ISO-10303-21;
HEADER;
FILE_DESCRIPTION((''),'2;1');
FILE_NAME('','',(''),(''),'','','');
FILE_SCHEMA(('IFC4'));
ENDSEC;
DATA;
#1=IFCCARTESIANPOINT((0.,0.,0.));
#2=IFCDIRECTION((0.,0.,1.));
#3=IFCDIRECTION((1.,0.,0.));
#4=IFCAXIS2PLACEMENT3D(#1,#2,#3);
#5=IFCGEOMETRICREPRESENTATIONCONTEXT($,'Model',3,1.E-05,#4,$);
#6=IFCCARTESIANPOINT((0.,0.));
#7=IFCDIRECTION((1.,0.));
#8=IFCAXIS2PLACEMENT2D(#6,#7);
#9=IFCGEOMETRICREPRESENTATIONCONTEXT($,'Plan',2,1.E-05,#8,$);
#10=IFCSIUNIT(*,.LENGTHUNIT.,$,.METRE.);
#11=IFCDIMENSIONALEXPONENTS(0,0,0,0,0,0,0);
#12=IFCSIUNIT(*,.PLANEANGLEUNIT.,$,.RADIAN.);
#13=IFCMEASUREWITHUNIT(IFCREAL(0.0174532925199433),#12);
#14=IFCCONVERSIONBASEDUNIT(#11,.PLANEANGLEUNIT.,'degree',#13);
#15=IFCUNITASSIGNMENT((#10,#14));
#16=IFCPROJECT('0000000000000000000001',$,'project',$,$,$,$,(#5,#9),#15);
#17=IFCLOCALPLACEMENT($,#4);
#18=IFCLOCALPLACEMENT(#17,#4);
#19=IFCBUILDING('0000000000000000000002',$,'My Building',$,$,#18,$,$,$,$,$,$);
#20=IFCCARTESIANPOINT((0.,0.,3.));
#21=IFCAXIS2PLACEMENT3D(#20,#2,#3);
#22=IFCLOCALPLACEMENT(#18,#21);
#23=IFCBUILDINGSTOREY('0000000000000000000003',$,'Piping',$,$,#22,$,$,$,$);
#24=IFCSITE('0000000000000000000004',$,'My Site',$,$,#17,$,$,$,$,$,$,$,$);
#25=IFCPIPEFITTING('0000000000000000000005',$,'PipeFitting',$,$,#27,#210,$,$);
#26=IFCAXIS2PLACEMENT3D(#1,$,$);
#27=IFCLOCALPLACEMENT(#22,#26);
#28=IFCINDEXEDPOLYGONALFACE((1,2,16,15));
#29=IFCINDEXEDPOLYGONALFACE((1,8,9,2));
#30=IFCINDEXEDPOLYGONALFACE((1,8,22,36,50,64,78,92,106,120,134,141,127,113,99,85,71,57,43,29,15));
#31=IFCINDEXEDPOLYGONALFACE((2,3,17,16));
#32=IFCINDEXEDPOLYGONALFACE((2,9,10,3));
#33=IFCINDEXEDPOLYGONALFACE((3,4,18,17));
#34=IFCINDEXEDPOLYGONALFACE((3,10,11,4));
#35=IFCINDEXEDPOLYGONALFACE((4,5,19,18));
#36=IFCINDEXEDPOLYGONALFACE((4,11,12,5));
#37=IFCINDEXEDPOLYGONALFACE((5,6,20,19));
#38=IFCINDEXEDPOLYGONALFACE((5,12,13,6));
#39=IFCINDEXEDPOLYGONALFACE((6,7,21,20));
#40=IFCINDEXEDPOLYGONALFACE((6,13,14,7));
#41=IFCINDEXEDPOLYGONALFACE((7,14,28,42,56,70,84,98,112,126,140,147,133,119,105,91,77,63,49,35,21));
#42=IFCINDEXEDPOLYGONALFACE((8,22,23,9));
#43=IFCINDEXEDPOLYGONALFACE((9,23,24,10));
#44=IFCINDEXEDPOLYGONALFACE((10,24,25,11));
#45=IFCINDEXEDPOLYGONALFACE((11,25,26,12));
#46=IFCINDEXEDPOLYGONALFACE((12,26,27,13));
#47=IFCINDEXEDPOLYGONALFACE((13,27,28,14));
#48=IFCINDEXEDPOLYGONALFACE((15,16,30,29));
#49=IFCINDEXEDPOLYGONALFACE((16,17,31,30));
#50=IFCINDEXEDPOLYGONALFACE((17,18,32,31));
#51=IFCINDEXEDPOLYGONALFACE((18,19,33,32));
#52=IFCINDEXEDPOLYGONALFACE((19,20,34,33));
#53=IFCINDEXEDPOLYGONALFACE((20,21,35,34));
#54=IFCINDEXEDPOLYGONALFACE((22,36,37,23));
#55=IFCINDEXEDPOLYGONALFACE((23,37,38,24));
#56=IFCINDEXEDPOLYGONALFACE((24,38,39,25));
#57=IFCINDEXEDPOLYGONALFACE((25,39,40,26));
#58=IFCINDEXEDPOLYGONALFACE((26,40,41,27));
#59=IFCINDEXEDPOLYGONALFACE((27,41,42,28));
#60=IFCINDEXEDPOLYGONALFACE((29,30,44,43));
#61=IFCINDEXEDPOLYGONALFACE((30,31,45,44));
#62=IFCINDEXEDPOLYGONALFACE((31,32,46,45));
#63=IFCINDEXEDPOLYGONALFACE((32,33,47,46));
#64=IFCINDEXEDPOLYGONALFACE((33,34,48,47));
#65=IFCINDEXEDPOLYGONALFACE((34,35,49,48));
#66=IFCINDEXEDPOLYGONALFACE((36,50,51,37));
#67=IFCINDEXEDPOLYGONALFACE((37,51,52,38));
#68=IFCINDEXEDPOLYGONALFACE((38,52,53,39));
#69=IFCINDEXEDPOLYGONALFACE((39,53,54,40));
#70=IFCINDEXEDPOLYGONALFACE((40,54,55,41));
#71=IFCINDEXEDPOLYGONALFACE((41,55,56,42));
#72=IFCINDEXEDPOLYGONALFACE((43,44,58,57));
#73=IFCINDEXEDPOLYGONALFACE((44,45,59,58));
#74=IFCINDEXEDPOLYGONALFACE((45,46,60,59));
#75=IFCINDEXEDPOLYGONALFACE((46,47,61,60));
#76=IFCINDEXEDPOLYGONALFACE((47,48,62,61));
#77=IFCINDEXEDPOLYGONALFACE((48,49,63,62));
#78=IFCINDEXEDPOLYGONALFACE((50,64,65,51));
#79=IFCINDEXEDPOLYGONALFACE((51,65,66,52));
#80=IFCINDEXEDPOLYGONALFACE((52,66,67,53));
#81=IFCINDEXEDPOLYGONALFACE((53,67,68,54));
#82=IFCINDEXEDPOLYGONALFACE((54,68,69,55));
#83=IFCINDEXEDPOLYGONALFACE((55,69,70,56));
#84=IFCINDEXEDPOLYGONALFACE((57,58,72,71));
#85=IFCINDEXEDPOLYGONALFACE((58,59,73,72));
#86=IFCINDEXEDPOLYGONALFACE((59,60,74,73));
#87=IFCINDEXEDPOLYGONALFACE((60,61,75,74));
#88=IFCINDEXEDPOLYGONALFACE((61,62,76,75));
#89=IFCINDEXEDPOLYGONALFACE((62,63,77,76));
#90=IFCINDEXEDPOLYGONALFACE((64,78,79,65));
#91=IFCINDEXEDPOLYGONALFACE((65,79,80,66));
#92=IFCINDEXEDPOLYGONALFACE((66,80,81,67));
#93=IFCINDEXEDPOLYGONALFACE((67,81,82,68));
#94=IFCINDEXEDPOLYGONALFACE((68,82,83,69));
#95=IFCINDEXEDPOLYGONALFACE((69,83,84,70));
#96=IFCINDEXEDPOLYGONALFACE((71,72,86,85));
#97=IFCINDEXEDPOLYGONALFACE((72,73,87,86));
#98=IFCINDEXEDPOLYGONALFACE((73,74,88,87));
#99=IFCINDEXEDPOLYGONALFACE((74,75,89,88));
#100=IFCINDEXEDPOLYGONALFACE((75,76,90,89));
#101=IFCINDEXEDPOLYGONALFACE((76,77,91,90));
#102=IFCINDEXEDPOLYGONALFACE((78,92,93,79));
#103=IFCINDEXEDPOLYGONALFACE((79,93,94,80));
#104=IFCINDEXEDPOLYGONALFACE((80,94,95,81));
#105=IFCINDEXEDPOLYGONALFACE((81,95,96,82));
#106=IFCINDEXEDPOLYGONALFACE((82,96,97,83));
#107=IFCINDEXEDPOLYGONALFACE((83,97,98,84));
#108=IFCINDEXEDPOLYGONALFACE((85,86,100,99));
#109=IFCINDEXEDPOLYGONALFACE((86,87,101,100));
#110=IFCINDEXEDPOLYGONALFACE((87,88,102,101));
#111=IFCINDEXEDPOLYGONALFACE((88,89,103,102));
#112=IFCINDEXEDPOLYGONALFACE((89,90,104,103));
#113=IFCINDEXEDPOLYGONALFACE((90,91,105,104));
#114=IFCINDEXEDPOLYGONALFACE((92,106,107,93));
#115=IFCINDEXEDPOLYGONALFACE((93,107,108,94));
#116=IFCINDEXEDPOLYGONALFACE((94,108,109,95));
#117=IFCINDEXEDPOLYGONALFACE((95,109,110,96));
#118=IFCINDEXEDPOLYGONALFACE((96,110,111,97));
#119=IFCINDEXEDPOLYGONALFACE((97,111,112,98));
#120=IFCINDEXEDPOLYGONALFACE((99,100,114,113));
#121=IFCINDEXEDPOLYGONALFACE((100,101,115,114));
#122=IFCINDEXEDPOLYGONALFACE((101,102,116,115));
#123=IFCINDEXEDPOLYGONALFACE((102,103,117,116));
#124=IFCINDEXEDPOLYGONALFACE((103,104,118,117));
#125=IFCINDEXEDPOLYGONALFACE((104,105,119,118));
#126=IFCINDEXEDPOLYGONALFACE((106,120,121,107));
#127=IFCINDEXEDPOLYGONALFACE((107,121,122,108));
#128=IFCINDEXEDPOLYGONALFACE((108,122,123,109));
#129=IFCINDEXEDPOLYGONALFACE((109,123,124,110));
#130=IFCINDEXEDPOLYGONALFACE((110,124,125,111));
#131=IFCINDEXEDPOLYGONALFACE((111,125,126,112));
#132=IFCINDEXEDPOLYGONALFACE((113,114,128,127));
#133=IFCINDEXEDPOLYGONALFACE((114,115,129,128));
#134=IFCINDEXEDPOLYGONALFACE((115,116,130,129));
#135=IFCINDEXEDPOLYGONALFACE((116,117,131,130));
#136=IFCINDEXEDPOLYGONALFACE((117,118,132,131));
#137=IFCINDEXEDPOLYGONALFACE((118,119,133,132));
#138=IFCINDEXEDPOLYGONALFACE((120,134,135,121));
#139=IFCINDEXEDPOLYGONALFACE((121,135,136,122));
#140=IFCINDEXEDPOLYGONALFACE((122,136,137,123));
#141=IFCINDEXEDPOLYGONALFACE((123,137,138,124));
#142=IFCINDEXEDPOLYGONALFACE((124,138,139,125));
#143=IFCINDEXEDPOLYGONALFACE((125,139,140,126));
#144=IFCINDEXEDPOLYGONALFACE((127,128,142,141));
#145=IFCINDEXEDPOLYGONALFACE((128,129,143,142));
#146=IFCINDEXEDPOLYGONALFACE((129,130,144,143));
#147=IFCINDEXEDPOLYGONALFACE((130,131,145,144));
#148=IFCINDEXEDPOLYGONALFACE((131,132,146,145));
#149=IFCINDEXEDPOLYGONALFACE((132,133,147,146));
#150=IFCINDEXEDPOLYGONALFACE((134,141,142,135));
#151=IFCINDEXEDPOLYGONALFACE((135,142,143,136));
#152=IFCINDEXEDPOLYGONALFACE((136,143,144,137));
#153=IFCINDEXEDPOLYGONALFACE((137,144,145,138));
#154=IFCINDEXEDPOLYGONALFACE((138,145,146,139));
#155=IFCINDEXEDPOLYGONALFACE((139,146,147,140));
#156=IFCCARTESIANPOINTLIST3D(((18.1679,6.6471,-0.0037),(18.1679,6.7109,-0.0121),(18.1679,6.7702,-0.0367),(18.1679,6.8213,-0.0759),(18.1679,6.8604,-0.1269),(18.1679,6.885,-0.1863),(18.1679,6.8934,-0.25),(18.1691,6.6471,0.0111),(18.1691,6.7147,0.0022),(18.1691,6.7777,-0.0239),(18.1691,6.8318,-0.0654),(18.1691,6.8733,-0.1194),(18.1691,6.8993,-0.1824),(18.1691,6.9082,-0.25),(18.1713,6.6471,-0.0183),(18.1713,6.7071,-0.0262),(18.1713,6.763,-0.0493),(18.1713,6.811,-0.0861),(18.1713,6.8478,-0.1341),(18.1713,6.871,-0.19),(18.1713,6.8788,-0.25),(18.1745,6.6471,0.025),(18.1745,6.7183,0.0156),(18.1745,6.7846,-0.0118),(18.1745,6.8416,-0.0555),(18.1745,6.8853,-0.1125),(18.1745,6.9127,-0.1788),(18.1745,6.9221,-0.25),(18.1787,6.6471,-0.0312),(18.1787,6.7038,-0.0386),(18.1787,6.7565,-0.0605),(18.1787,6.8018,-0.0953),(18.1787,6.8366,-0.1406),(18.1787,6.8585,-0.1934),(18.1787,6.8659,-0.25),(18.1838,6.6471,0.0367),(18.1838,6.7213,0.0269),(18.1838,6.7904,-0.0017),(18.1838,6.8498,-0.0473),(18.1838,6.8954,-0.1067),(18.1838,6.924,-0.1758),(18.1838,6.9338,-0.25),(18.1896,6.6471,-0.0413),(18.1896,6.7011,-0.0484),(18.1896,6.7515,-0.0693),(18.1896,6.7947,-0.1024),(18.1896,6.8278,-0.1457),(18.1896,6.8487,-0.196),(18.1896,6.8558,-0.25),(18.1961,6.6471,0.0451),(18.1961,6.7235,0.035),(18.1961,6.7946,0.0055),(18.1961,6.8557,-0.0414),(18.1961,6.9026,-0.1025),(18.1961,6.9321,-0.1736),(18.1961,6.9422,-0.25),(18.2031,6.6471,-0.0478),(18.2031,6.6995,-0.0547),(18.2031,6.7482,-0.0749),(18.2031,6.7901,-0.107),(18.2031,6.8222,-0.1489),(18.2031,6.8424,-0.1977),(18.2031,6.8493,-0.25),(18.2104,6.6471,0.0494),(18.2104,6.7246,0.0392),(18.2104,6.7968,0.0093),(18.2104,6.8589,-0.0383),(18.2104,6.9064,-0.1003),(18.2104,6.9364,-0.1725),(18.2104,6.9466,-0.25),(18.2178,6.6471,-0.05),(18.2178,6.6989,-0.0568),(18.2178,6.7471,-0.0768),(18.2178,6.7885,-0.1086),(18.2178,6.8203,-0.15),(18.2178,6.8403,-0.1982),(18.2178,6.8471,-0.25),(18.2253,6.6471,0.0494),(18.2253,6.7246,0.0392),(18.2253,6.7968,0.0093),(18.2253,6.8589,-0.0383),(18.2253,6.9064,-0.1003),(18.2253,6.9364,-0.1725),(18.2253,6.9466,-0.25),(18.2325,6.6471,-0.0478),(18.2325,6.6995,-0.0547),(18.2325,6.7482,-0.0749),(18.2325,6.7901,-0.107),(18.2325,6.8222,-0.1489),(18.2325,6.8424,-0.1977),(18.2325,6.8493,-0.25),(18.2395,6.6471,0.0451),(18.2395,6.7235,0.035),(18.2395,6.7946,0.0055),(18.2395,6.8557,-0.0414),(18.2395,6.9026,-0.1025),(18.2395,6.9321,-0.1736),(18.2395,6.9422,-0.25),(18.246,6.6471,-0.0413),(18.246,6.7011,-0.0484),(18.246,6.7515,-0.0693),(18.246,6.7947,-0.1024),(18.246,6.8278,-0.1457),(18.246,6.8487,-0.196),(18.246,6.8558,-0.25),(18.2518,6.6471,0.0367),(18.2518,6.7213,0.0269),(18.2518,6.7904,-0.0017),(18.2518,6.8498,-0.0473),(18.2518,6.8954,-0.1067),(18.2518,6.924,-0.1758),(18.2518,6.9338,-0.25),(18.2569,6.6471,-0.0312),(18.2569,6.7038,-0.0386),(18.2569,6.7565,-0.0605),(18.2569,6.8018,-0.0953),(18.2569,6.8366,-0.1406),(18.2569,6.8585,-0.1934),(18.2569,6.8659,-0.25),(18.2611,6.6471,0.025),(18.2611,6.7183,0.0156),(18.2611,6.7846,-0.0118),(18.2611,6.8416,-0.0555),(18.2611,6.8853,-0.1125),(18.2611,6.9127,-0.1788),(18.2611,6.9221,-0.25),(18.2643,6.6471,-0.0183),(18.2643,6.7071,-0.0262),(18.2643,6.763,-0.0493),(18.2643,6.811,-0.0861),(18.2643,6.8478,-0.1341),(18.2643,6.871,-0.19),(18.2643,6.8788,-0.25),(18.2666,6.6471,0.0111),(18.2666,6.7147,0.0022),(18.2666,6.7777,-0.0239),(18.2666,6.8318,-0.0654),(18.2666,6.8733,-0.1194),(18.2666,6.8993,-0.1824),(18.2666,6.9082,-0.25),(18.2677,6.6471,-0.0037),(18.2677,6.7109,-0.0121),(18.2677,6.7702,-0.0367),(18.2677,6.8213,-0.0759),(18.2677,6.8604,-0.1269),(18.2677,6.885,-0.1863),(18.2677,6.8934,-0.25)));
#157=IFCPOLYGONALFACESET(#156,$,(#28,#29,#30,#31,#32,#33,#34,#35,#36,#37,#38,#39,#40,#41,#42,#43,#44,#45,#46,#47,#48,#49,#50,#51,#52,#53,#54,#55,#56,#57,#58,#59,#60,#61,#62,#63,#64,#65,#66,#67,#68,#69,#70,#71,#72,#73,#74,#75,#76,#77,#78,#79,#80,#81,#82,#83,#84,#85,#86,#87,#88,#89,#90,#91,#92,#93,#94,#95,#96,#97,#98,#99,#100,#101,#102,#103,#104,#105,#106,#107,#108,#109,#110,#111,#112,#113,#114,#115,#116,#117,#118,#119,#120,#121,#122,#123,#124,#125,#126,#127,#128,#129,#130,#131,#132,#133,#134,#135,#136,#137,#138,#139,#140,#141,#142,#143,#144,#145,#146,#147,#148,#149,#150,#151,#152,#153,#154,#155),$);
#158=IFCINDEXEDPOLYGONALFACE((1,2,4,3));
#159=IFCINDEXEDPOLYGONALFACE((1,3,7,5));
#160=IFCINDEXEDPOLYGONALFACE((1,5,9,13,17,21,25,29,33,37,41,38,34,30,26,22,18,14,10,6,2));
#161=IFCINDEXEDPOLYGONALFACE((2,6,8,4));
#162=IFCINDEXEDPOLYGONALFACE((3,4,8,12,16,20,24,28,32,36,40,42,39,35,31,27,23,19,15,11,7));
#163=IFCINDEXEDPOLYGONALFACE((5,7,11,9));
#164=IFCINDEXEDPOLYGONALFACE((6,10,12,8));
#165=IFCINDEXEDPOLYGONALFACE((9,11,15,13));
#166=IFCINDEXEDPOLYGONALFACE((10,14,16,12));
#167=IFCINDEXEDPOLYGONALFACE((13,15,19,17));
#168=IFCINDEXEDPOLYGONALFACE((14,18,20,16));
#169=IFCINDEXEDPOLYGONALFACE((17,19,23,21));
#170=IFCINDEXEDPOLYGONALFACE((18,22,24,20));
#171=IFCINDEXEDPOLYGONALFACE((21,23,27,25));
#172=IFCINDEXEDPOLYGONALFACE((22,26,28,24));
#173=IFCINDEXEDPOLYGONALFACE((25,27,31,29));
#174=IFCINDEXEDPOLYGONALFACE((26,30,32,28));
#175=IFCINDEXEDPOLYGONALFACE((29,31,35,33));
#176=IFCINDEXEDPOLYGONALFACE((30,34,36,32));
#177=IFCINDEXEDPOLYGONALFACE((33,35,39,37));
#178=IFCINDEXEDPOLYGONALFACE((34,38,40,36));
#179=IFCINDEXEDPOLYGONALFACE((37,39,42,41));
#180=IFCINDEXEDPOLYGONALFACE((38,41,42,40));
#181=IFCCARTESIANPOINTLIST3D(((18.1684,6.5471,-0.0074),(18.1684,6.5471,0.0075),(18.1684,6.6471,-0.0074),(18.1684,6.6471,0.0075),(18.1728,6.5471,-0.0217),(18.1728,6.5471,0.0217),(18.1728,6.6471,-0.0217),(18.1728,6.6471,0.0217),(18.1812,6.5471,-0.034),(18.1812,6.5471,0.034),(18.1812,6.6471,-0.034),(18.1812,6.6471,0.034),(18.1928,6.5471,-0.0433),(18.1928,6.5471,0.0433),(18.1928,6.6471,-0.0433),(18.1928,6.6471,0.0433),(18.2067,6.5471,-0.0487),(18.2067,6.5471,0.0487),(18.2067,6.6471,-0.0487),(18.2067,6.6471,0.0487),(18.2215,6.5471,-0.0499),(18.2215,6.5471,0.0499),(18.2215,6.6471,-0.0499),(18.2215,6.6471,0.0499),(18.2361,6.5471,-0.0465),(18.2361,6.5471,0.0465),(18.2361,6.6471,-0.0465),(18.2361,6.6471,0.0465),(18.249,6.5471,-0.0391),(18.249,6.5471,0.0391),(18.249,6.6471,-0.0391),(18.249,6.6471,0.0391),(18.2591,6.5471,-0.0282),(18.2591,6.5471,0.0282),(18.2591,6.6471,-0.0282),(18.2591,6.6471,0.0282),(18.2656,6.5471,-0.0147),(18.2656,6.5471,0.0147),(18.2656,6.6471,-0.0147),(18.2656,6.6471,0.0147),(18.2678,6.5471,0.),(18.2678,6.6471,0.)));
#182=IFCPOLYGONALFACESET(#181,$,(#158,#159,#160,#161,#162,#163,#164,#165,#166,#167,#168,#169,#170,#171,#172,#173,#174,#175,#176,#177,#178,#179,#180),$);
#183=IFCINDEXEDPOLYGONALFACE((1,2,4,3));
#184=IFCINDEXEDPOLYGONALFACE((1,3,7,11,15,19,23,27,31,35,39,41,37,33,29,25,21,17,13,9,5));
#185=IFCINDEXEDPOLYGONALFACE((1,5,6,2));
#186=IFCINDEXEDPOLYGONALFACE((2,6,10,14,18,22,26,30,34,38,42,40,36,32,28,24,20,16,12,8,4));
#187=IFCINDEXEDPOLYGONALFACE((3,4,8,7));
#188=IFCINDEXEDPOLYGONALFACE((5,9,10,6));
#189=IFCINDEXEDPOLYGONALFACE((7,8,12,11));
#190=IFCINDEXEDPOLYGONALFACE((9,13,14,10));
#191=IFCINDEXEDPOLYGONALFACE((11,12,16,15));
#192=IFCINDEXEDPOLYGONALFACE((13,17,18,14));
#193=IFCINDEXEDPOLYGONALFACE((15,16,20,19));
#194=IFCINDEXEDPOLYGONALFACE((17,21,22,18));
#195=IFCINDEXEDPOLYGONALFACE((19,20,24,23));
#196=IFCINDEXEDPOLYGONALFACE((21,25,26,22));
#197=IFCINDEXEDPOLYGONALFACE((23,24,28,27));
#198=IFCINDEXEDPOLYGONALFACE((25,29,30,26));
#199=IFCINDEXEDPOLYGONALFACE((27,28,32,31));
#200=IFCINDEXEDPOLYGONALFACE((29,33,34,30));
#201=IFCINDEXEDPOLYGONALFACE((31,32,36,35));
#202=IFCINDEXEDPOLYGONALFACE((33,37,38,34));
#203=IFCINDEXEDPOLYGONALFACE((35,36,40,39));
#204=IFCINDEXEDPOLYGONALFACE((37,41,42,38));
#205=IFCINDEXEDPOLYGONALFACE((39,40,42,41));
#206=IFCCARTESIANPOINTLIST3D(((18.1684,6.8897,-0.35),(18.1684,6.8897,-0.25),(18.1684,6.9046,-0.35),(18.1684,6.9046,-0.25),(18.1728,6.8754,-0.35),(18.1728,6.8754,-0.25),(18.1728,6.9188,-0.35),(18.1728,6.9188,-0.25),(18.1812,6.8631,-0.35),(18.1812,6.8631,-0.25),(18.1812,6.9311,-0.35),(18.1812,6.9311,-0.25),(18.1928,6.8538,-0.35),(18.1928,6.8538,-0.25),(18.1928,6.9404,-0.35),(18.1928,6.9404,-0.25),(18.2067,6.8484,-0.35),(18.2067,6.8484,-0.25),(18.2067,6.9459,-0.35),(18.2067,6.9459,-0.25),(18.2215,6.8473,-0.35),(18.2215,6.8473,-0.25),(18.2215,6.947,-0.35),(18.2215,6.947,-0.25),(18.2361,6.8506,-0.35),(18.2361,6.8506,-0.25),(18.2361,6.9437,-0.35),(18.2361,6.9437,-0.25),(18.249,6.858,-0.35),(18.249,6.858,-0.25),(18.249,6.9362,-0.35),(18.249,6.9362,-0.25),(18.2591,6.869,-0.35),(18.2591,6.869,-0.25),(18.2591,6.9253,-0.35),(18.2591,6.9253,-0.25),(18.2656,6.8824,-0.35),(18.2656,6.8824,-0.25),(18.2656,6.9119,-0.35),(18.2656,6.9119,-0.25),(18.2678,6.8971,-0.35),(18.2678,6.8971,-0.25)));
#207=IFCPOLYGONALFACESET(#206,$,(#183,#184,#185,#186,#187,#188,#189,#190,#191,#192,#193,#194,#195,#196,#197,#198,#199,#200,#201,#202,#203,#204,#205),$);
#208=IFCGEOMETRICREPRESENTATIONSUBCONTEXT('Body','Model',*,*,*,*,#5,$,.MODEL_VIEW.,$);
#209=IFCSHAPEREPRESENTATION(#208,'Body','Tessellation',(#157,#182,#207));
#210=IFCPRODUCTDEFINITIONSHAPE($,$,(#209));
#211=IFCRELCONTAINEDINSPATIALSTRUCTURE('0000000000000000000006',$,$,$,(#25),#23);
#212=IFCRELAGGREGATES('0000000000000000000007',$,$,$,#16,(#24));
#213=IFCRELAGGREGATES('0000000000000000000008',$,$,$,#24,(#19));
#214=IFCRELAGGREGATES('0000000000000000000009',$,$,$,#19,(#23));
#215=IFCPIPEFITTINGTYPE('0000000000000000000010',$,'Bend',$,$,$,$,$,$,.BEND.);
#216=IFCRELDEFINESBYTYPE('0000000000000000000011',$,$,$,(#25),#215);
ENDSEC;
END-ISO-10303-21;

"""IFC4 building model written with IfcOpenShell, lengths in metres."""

from ifc_helpers import new_model, entity, si_unit, converted_unit, frame, origin_with_axes, origin_2d_with_axis, place, context, subcontext, project, spatial, circle, extrude, source, transform, mapped, type_object, type_shapes, element, save


model = new_model("IFC4")

# Units and contexts
model_context = context("Model", 3, precision=1e-05, world=origin_with_axes())
plan_context = context("Plan", 2, precision=1e-05, world=origin_2d_with_axis())
body_context = subcontext(model_context, "Body", "Model", "MODEL_VIEW")
ifc_project = project(units=[si_unit("LENGTHUNIT", "METRE"), converted_unit("PLANEANGLEUNIT", "degree", entity("IfcReal", 0.0174532925199433), si_unit("PLANEANGLEUNIT", "RADIAN"), dimensions=[0, 0, 0, 0, 0, 0, 0])], contexts=[model_context, plan_context])

# Site, building, storey
site_placement = place(None, origin_with_axes())
site = spatial("IfcSite", under=ifc_project, at=site_placement, Name="My Site")
building_placement = place(site_placement, origin_with_axes())
building = spatial("IfcBuilding", under=site, at=building_placement, Name="My Building")
storey_placement = place(building_placement, frame((0.0, 0.0, 3.0), z_axis=(0.0, 0.0, 1.0), x_axis=(1.0, 0.0, 0.0)))
storey = spatial("IfcBuildingStorey", under=building, at=storey_placement, Name="Piping")

# Pipe fitting
pipe_fitting_type = type_object("IfcPipeFittingType", Name="Bend", PredefinedType="BEND")
shared_shape = source(origin_with_axes(), body_context, "Body", "SolidModel", [
    entity("IfcSweptDiskSolid", entity("IfcIndexedPolyCurve", entity("IfcCartesianPointList3D", [[0.0, 0.0, -0.1], [0.0, -0.0732, -0.2768], [0.0, -0.25, -0.35]]), [entity("IfcArcIndex", [1, 2, 3])]), 0.05),
    extrude(circle(Radius=0.05), origin_with_axes(), (0.0, 0.0, -1.0), 0.1),
    extrude(circle(Radius=0.05), frame((0.0, -0.25, -0.35), z_axis=(0.0, -1.0, 0.0), x_axis=(1.0, 0.0, 0.0)), (0.0, 0.0, 1.0), 0.1),
])
type_shapes(pipe_fitting_type, [shared_shape])
for number, where, z_axis, x_axis, name in (
    (1, (18.2178, 6.5471, 0.0), (0.0, -1.0, 0.0), (1.0, 0.0, 0.0), "PipeFitting"),
):
    element("IfcPipeFitting", number, at=place(storey_placement, frame(where, z_axis=z_axis, x_axis=x_axis)), inside=storey, type_object=pipe_fitting_type, Name=name, context=body_context, shape_type="MappedRepresentation", body=[
        mapped(shared_shape, transform((0.0, 0.0, 0.0), x_axis=(1.0, 0.0, 0.0), y_axis=(0.0, 1.0, 0.0), z_axis=(0.0, 0.0, 1.0), scale=1.0)),
    ])

save(model, "model.ifc")
